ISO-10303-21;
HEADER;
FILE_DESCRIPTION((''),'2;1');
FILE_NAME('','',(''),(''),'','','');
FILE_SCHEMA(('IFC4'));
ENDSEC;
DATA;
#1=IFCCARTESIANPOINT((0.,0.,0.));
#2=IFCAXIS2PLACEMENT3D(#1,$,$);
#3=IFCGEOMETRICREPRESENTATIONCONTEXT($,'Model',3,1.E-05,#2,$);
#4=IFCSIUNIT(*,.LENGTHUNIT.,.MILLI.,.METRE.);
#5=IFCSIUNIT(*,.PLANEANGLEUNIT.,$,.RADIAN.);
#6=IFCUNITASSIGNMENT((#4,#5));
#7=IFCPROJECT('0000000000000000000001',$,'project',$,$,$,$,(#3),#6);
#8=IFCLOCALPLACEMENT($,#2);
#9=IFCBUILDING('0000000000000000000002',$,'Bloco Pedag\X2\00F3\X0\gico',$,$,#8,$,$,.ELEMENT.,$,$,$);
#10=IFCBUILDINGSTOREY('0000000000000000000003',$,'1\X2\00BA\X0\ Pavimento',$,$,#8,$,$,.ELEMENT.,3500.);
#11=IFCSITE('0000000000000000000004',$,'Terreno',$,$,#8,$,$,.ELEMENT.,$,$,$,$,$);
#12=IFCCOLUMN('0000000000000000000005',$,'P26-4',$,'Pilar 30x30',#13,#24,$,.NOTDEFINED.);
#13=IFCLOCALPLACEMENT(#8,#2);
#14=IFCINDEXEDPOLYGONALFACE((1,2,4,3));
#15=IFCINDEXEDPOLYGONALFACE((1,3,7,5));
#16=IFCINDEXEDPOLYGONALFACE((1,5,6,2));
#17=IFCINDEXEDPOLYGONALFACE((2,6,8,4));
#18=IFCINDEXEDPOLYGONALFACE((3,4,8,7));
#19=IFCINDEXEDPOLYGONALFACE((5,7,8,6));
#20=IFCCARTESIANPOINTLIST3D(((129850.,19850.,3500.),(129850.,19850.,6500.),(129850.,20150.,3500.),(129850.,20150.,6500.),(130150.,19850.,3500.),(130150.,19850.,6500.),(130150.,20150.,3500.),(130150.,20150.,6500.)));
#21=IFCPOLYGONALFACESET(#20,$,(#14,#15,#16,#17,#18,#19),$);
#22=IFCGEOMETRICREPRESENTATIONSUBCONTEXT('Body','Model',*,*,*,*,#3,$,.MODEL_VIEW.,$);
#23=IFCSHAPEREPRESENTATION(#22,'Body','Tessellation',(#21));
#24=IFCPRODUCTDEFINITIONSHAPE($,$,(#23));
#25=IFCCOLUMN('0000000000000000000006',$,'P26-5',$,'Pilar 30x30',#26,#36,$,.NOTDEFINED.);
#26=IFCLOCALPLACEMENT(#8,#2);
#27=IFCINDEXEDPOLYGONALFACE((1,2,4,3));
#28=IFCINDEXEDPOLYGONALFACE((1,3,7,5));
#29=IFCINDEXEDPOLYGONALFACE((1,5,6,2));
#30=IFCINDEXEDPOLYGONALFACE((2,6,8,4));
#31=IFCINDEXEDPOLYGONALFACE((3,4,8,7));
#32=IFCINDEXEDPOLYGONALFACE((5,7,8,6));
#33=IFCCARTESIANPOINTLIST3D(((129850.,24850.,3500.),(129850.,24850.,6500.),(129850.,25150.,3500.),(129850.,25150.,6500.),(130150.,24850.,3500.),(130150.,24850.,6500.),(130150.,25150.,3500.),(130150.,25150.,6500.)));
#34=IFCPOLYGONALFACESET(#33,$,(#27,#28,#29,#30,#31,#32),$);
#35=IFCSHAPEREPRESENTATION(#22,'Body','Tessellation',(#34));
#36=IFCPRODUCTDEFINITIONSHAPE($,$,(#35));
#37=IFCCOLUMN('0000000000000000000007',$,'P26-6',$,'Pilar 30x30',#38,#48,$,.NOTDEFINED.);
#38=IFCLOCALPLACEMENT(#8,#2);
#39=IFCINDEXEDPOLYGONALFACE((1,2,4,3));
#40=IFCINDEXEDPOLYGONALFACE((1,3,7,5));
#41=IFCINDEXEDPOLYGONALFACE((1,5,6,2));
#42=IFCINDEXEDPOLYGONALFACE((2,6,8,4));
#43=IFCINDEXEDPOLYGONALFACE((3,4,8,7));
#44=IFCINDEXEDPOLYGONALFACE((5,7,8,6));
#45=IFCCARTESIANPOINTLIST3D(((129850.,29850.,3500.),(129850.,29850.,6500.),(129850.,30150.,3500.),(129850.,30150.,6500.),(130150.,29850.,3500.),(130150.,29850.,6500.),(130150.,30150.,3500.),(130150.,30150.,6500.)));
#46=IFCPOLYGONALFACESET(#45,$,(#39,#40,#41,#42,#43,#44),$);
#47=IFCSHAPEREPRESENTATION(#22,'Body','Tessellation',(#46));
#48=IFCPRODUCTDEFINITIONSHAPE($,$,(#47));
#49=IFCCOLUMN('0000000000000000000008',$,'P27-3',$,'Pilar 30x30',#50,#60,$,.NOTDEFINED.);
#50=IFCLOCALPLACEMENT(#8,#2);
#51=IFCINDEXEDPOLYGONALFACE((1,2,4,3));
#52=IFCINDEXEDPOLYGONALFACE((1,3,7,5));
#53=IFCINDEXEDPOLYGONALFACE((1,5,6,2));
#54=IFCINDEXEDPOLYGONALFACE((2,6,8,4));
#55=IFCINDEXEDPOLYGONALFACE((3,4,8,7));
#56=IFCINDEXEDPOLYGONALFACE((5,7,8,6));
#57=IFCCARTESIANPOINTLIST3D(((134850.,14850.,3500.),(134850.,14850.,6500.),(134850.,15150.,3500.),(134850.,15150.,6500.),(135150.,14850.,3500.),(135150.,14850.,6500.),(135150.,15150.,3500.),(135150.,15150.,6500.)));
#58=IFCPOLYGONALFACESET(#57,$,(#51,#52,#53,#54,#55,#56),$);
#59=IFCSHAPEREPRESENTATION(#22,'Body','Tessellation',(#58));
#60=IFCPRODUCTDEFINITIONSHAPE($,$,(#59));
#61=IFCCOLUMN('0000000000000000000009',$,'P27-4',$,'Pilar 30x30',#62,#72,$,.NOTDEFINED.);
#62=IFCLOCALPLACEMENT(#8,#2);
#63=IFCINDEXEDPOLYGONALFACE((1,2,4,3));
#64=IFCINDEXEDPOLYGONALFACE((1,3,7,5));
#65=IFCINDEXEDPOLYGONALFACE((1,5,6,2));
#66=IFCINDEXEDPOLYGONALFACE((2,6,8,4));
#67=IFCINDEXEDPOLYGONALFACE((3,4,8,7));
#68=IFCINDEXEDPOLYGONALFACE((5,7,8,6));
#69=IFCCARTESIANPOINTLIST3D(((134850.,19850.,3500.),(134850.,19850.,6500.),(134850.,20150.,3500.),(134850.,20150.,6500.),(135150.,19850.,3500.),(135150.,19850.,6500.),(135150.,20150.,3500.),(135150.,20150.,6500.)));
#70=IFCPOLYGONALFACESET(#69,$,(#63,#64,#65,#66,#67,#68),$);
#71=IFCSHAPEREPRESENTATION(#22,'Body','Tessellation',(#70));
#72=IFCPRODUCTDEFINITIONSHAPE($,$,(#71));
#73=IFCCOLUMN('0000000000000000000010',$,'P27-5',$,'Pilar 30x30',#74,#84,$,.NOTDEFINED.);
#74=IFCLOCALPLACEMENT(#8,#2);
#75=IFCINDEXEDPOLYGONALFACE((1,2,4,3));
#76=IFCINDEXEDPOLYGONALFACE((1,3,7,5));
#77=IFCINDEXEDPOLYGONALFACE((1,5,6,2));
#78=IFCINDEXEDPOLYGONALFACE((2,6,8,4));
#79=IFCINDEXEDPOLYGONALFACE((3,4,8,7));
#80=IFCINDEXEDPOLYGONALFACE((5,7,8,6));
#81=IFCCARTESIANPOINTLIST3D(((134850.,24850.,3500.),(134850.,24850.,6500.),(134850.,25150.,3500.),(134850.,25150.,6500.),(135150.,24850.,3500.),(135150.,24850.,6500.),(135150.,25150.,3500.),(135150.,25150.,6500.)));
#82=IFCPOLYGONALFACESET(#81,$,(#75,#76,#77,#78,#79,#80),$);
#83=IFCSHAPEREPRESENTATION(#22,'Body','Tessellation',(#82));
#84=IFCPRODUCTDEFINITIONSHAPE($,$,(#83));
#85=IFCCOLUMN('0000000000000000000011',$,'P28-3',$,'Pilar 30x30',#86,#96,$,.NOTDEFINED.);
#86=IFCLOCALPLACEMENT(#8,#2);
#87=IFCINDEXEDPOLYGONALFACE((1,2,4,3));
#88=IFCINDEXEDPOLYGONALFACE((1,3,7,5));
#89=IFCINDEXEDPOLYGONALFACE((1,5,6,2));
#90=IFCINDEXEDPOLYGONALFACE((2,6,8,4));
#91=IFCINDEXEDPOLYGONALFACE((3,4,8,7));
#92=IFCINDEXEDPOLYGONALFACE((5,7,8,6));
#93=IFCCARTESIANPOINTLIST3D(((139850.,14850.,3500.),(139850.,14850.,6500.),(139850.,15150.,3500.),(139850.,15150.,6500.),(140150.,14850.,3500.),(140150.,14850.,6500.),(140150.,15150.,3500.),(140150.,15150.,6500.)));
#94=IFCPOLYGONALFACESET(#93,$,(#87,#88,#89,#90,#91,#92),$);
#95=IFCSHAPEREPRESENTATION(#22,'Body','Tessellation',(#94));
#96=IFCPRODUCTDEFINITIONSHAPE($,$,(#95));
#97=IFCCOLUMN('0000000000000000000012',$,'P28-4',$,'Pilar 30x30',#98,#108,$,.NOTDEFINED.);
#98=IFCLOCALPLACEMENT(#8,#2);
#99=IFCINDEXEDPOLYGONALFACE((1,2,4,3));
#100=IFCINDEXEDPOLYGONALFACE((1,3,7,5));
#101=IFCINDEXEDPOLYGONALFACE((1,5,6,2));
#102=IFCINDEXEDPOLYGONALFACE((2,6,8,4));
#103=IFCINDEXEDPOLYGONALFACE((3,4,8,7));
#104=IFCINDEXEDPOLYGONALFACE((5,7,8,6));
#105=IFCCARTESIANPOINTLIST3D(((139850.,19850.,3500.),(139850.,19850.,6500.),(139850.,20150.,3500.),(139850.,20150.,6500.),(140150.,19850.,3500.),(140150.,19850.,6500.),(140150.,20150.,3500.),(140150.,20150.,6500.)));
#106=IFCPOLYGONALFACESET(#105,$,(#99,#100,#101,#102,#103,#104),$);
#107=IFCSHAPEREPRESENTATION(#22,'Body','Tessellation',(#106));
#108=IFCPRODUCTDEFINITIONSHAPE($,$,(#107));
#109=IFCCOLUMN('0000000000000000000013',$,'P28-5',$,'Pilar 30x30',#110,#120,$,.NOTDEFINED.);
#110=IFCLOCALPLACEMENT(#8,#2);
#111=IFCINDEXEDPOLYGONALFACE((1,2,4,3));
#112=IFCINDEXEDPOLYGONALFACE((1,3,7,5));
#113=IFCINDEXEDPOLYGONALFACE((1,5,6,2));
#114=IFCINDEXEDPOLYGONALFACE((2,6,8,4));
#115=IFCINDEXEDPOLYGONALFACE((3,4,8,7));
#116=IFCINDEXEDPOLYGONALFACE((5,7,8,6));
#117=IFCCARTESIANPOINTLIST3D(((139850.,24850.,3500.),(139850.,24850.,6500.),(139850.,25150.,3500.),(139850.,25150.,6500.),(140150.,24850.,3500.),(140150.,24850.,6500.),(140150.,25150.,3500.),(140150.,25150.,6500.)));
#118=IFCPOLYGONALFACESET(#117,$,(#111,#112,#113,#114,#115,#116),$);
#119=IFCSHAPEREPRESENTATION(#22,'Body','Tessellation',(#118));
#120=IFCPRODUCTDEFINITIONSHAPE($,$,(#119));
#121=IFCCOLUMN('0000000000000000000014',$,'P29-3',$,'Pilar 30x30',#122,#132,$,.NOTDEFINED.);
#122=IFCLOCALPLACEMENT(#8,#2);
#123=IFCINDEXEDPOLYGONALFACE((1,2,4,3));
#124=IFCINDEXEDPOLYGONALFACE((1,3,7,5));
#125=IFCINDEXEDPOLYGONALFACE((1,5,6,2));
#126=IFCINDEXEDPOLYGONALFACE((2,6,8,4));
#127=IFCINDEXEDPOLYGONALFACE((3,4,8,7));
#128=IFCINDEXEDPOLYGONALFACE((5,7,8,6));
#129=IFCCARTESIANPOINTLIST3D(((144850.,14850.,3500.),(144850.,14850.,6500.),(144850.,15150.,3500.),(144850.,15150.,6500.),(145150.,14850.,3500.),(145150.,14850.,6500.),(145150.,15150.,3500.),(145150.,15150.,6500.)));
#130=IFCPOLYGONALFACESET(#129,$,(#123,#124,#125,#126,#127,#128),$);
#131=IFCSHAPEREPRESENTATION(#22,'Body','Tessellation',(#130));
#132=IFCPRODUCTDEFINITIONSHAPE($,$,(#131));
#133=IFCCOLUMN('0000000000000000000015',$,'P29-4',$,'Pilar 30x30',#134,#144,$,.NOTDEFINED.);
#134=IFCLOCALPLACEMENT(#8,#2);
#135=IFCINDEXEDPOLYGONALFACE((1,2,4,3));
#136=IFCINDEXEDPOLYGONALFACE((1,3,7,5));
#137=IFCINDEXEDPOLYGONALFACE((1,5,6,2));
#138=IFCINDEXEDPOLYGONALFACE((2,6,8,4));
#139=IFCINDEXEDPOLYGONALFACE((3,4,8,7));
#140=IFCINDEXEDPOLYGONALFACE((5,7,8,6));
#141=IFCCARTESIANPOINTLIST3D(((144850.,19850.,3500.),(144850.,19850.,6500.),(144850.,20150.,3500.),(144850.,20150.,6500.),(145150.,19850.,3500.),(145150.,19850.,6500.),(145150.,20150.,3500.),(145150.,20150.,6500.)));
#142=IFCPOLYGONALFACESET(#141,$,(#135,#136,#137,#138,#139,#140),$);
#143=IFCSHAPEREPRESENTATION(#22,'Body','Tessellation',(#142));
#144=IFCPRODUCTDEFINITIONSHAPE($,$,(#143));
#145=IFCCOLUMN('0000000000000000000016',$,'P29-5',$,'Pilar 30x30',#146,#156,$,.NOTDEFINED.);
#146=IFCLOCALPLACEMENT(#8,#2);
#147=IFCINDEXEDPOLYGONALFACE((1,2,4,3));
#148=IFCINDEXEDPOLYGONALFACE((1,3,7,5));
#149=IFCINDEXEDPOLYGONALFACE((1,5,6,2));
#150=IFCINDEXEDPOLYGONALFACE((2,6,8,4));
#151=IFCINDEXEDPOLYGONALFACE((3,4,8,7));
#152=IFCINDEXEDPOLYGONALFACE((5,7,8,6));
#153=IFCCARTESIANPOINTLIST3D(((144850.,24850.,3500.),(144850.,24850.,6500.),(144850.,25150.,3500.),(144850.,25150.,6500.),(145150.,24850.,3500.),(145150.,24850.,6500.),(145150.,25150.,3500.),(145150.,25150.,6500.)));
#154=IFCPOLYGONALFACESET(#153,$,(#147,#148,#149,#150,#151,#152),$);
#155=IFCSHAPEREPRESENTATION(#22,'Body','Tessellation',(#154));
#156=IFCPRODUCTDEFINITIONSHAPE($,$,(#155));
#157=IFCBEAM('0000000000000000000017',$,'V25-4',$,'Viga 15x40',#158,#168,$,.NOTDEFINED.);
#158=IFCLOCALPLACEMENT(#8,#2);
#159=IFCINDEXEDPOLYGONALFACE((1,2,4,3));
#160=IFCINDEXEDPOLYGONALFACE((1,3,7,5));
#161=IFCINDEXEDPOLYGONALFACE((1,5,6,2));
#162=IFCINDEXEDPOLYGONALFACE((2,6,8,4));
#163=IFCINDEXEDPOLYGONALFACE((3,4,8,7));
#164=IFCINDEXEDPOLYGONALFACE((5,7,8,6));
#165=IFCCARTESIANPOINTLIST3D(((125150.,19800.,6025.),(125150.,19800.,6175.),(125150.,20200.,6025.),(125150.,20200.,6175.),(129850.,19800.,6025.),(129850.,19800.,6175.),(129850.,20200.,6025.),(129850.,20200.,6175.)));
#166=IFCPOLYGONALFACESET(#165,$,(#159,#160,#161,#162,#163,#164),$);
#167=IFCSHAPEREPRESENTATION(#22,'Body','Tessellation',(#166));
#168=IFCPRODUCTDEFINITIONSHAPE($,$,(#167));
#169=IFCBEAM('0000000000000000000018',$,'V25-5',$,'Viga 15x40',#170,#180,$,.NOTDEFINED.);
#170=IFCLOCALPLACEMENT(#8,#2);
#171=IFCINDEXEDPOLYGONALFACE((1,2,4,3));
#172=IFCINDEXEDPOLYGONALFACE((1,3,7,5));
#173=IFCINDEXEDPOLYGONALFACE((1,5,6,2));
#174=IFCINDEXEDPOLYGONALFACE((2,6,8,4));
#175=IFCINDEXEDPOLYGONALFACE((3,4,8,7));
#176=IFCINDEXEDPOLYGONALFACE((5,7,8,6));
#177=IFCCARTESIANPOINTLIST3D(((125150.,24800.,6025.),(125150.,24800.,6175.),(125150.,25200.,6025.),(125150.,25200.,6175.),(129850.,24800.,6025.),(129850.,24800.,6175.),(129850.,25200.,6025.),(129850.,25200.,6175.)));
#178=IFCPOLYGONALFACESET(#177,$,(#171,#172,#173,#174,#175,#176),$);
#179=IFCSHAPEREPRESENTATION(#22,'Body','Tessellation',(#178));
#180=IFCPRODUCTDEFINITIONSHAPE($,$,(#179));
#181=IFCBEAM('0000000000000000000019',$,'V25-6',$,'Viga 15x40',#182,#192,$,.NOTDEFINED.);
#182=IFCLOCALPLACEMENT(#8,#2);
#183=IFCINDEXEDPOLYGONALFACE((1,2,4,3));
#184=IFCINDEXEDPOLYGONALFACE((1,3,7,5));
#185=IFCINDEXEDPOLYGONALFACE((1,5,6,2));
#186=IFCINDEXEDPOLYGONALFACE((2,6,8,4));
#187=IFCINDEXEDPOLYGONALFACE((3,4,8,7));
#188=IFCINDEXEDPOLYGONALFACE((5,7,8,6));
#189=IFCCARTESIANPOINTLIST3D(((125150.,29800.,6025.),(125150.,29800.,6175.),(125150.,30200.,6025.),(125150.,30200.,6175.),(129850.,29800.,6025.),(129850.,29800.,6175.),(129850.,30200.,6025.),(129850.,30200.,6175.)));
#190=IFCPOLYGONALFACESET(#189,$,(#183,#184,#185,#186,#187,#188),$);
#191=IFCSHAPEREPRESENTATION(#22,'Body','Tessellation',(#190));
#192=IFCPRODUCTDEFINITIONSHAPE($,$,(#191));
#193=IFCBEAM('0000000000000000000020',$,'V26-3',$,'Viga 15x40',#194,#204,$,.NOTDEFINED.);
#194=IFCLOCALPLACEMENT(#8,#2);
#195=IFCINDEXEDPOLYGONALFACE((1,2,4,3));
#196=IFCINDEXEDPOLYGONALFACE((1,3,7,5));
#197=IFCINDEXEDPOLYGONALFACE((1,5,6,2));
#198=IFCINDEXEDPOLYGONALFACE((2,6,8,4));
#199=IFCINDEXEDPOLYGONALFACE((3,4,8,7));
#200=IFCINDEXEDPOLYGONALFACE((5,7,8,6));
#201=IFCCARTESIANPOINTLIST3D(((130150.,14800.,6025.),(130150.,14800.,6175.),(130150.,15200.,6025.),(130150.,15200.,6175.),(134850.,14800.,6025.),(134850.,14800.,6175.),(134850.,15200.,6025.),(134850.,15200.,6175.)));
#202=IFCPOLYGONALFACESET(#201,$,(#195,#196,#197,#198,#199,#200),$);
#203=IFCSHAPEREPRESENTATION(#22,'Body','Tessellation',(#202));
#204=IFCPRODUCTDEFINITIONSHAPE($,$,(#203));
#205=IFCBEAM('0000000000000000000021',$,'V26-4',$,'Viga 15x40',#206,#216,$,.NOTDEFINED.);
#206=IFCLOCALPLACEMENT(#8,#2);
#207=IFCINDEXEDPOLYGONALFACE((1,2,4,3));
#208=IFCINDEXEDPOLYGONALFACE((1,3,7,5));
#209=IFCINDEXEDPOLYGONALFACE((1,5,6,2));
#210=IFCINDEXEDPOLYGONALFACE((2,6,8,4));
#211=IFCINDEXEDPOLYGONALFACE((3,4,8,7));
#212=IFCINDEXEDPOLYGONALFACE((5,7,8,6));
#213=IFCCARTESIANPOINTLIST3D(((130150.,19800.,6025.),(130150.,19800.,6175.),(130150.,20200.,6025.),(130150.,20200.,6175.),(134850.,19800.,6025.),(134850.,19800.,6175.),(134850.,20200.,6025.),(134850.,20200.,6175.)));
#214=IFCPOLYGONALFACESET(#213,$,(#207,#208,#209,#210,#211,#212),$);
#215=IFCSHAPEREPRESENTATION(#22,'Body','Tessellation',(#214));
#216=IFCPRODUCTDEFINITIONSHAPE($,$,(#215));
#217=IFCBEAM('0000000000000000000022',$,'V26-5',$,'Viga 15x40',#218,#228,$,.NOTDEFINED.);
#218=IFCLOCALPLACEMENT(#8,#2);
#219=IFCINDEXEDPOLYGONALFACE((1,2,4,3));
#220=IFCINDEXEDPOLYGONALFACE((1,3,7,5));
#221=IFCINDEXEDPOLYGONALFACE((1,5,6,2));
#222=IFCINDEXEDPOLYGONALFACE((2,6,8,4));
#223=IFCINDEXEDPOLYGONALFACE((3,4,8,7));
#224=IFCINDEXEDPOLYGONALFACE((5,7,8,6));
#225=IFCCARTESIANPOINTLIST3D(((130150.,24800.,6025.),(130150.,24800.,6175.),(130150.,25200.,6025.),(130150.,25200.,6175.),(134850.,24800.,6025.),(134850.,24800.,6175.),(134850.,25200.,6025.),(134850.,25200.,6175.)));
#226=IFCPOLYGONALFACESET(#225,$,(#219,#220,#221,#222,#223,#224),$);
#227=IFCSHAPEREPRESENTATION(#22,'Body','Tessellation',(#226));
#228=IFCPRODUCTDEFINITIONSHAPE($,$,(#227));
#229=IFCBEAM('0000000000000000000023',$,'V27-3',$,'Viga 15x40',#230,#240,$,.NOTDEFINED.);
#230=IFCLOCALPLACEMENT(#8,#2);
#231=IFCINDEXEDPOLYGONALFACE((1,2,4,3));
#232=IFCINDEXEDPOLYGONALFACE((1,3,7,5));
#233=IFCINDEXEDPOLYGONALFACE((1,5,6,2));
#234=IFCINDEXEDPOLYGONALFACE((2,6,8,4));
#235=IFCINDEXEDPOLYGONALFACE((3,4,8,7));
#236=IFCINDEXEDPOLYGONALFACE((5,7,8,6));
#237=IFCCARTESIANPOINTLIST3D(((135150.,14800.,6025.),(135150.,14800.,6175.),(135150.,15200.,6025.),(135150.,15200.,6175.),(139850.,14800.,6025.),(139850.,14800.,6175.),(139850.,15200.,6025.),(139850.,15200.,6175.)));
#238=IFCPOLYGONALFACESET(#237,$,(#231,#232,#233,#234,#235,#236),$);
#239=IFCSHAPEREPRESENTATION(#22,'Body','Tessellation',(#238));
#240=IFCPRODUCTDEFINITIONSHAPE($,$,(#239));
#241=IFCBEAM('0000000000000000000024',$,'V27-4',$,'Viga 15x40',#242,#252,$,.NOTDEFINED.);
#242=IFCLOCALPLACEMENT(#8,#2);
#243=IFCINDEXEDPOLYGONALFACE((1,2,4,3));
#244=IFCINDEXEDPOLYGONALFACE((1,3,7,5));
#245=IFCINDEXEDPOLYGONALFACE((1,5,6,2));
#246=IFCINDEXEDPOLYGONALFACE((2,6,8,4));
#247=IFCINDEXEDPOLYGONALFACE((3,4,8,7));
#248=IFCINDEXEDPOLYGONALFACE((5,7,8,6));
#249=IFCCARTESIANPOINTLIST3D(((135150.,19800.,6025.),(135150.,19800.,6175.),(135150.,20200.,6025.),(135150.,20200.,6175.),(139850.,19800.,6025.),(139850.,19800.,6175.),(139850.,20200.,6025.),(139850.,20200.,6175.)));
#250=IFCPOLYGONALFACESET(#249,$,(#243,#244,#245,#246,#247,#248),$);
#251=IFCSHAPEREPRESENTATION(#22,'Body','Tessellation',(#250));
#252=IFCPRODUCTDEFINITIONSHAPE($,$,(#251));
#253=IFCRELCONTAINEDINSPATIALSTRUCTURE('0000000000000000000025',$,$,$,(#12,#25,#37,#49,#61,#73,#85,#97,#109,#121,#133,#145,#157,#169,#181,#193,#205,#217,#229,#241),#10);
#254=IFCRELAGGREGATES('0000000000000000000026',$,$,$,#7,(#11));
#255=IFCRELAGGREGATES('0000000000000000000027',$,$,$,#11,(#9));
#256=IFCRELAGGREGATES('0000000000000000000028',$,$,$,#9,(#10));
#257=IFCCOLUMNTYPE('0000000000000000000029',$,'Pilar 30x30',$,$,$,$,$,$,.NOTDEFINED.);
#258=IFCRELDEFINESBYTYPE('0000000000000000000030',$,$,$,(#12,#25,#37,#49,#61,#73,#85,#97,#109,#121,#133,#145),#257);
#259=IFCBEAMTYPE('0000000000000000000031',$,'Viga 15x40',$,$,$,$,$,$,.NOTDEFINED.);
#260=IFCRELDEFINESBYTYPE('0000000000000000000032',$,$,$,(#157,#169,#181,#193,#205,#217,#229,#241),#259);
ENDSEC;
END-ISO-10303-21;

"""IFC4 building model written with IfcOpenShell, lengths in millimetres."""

from ifc_helpers import new_model, si_unit, frame, origin, origin_2d, place, context, subcontext, project, spatial, rectangle, extrude, type_object, element, save


model = new_model("IFC4")

# Units and contexts
model_context = context("Model", 3, precision=1e-05, world=origin())
body_context = subcontext(model_context, "Body", "Model", "MODEL_VIEW")
ifc_project = project(units=[si_unit("LENGTHUNIT", "METRE", prefix="MILLI"), si_unit("PLANEANGLEUNIT", "RADIAN")], contexts=[model_context])

# Site, building, storey
placement = place(None, origin())
site = spatial("IfcSite", under=ifc_project, at=placement, Name="Terreno", CompositionType="ELEMENT")
building = spatial("IfcBuilding", under=site, at=placement, Name="Bloco Pedagógico", CompositionType="ELEMENT")
storey = spatial("IfcBuildingStorey", under=building, at=placement, Name="1º Pavimento", CompositionType="ELEMENT", Elevation=3500.0)

# Columns
column_type = type_object("IfcColumnType", Name="Pilar 30x30", PredefinedType="NOTDEFINED")
for number, where, z_axis, x_axis, name in (
    (1, (130000.0, 20000.0, 3500.0), (0.0, 0.0, 1.0), (1.0, 0.0, 0.0), "P26-4"),
    (2, (130000.0, 25000.0, 3500.0), (0.0, 0.0, 1.0), (1.0, 0.0, 0.0), "P26-5"),
    (3, (130000.0, 30000.0, 3500.0), (0.0, 0.0, 1.0), (1.0, 0.0, 0.0), "P26-6"),
    (4, (135000.0, 15000.0, 3500.0), (0.0, 0.0, 1.0), (1.0, 0.0, 0.0), "P27-3"),
    (5, (135000.0, 20000.0, 3500.0), (0.0, 0.0, 1.0), (1.0, 0.0, 0.0), "P27-4"),
    (6, (135000.0, 25000.0, 3500.0), (0.0, 0.0, 1.0), (1.0, 0.0, 0.0), "P27-5"),
    (7, (140000.0, 15000.0, 3500.0), (0.0, 0.0, 1.0), (1.0, 0.0, 0.0), "P28-3"),
    (8, (140000.0, 20000.0, 3500.0), (0.0, 0.0, 1.0), (1.0, 0.0, 0.0), "P28-4"),
    (9, (140000.0, 25000.0, 3500.0), (0.0, 0.0, 1.0), (1.0, 0.0, 0.0), "P28-5"),
    (10, (145000.0, 15000.0, 3500.0), (0.0, 0.0, 1.0), (1.0, 0.0, 0.0), "P29-3"),
    (11, (145000.0, 20000.0, 3500.0), (0.0, 0.0, 1.0), (1.0, 0.0, 0.0), "P29-4"),
    (12, (145000.0, 25000.0, 3500.0), (0.0, 0.0, 1.0), (1.0, 0.0, 0.0), "P29-5"),
):
    element("IfcColumn", number, at=place(None, frame(where, z_axis=z_axis, x_axis=x_axis)), inside=storey, type_object=column_type, Name=name, ObjectType="Pilar 30x30", PredefinedType="NOTDEFINED", context=body_context, shape_type="SweptSolid", body=[
        extrude(rectangle(XDim=300.0, YDim=300.0, at=origin_2d()), None, (0.0, 0.0, 1.0), 3000.0),
    ])

# Beams
beam_type = type_object("IfcBeamType", Name="Viga 15x40", PredefinedType="NOTDEFINED")
for number, where, z_axis, x_axis, name in (
    (13, (125150.0, 20000.0, 6100.0), (1.0, 0.0, 0.0), (0.0, 1.0, 0.0), "V25-4"),
    (14, (125150.0, 25000.0, 6100.0), (1.0, 0.0, 0.0), (0.0, 1.0, 0.0), "V25-5"),
    (15, (125150.0, 30000.0, 6100.0), (1.0, 0.0, 0.0), (0.0, 1.0, 0.0), "V25-6"),
    (16, (130150.0, 15000.0, 6100.0), (1.0, 0.0, 0.0), (0.0, 1.0, 0.0), "V26-3"),
    (17, (130150.0, 20000.0, 6100.0), (1.0, 0.0, 0.0), (0.0, 1.0, 0.0), "V26-4"),
    (18, (130150.0, 25000.0, 6100.0), (1.0, 0.0, 0.0), (0.0, 1.0, 0.0), "V26-5"),
    (19, (135150.0, 15000.0, 6100.0), (1.0, 0.0, 0.0), (0.0, 1.0, 0.0), "V27-3"),
    (20, (135150.0, 20000.0, 6100.0), (1.0, 0.0, 0.0), (0.0, 1.0, 0.0), "V27-4"),
):
    element("IfcBeam", number, at=place(None, frame(where, z_axis=z_axis, x_axis=x_axis)), inside=storey, type_object=beam_type, Name=name, ObjectType="Viga 15x40", PredefinedType="NOTDEFINED", context=body_context, shape_type="SweptSolid", body=[
        extrude(rectangle(XDim=400.0, YDim=150.0, at=origin_2d()), None, (0.0, 0.0, 1.0), 4700.0),
    ])

save(model, "model.ifc")
